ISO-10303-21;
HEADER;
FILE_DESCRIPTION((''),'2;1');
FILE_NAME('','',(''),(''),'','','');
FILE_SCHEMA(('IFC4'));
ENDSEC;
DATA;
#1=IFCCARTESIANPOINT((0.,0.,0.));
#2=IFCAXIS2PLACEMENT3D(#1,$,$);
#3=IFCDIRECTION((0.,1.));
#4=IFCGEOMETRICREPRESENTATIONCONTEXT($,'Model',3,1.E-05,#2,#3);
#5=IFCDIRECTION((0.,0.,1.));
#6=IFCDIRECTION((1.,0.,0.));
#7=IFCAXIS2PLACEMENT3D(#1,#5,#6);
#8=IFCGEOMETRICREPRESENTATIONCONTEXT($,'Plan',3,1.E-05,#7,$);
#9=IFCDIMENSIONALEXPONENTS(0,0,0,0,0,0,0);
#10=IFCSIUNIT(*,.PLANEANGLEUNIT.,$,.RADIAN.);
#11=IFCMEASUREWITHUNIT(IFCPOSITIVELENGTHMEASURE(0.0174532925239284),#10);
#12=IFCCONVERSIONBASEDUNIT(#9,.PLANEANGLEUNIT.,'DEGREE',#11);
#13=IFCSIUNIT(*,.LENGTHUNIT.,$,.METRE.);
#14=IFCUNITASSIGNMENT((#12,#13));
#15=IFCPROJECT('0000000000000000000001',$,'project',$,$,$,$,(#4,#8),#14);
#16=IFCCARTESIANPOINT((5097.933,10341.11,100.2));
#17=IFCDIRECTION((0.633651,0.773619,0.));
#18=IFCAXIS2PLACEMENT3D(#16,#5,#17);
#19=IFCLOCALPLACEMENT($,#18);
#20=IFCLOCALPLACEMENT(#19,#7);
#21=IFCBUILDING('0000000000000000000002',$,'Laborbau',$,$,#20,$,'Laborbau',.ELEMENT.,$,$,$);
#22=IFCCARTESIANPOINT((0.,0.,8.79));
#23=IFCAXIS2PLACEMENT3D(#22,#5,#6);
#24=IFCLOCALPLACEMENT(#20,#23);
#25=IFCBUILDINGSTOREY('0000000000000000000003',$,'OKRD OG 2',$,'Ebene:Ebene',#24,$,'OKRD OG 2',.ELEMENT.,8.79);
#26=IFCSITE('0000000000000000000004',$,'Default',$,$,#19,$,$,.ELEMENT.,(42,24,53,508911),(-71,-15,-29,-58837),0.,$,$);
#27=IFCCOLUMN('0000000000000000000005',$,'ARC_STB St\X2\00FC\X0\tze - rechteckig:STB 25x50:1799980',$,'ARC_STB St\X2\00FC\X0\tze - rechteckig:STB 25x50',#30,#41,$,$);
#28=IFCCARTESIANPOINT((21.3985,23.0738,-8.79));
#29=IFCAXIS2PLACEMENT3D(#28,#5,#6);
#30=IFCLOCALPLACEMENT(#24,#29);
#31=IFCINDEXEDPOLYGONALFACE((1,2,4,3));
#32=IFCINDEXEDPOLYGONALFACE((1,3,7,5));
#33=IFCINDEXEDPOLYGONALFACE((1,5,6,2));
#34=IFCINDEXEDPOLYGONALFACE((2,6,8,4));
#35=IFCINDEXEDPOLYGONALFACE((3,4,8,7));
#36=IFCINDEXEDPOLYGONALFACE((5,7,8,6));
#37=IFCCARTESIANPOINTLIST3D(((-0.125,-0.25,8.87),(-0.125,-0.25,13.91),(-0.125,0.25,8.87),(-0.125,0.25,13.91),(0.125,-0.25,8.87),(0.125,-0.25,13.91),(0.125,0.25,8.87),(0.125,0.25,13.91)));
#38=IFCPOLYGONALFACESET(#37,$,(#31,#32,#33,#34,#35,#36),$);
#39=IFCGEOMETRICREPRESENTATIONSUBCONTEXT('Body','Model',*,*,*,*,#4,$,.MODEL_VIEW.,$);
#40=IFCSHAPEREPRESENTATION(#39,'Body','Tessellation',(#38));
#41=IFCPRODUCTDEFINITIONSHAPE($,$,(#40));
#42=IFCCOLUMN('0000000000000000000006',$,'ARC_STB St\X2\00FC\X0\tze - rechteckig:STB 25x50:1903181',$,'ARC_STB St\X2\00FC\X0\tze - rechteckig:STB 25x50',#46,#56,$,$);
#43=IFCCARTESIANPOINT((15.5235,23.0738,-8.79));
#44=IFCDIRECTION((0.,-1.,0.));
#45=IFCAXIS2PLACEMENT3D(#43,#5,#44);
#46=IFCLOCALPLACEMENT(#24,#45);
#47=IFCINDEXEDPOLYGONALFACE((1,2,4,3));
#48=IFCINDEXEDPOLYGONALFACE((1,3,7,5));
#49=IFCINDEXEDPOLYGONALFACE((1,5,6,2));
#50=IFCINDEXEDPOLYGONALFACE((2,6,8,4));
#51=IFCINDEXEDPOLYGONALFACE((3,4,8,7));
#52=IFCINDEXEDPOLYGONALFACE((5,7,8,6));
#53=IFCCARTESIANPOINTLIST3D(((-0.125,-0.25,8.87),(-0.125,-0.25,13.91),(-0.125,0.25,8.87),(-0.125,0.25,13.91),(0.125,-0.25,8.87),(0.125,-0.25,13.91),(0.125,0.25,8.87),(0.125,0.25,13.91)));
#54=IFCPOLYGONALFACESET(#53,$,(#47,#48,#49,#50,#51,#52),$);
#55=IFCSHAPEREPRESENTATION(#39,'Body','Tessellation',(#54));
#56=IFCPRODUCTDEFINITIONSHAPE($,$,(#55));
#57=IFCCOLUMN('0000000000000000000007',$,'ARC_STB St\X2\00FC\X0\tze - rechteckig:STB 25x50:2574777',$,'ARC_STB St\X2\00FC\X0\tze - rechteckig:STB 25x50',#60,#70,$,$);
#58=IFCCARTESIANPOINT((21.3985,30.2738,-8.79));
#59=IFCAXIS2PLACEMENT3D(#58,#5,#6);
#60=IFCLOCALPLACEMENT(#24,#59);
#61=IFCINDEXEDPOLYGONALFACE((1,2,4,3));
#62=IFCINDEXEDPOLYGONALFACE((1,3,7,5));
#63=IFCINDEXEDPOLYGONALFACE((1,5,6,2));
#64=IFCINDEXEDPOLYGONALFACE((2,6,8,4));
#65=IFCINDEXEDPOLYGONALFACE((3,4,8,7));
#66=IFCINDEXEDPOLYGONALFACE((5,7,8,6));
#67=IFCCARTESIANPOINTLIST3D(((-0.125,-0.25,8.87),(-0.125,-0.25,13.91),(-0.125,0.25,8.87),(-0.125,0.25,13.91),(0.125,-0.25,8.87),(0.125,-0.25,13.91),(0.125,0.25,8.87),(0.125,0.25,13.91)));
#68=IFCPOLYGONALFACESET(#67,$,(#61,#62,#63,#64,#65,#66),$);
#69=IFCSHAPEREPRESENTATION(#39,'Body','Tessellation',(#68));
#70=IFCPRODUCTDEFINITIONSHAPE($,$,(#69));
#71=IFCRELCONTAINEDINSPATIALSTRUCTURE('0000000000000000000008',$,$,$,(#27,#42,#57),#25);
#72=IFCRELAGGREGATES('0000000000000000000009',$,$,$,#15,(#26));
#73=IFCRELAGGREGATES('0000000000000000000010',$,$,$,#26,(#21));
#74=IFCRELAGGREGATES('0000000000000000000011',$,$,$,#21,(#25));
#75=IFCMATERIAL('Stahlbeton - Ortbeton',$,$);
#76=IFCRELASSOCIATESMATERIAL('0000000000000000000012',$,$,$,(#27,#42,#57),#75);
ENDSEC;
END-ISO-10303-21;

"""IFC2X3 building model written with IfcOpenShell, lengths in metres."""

from ifc_helpers import new_model, entity, si_unit, converted_unit, direction, frame, origin, origin_with_axes, origin_2d_with_axis, place, context, subcontext, project, spatial, rectangle, extrude, source, transform, mapped, material, element, save


model = new_model("IFC2X3")

# Units and contexts
model_context = context("Model", 3, precision=1e-05, world=origin(), true_north=direction((0.0, 1.0)))
plan_context = context("Plan", 3, precision=1e-05, world=origin_with_axes())
body_context = subcontext(model_context, "Body", "Model", "MODEL_VIEW")
ifc_project = project(units=[converted_unit("PLANEANGLEUNIT", "DEGREE", entity("IfcPositiveLengthMeasure", 0.0174532925239284), si_unit("PLANEANGLEUNIT", "RADIAN"), dimensions=[0, 0, 0, 0, 0, 0, 0]), si_unit("LENGTHUNIT", "METRE")], contexts=[model_context, plan_context])

# Site, building, storey
site_placement = place(None, frame((5097.933, 10341.11, 100.2), z_axis=(0.0, 0.0, 1.0), x_axis=(0.633651, 0.773619, 0.0)))
site = spatial("IfcSite", under=ifc_project, at=site_placement, Name="Default", CompositionType="ELEMENT", RefLatitude=(42, 24, 53, 508911), RefLongitude=(-71, -15, -29, -58837), RefElevation=0.0)
building_placement = place(site_placement, origin_with_axes())
building = spatial("IfcBuilding", under=site, at=building_placement, Name="Laborbau", LongName="Laborbau", CompositionType="ELEMENT")
storey_placement = place(building_placement, frame((0.0, 0.0, 8.79), z_axis=(0.0, 0.0, 1.0), x_axis=(1.0, 0.0, 0.0)))
storey = spatial("IfcBuildingStorey", under=building, at=storey_placement, Name="OKRD OG 2", ObjectType="Ebene:Ebene", LongName="OKRD OG 2", CompositionType="ELEMENT", Elevation=8.79)

# Columns
ifc_material_1 = material(Name="Stahlbeton - Ortbeton")
shared_shape = source(origin(), body_context, "Body", "SweptSolid", [
    extrude(rectangle(XDim=0.5, YDim=0.25, at=origin_2d_with_axis()), frame((0.0, 0.0, 8.87), z_axis=(0.0, 0.0, 1.0), x_axis=(0.0, -1.0, 0.0)), (0.0, 0.0, 1.0), 5.04),
])
for number, where, z_axis, x_axis, name in (
    (1, (21.3985, 23.0738, -8.79), (0.0, 0.0, 1.0), (1.0, 0.0, 0.0), "ARC_STB Stütze - rechteckig:STB 25x50:1799980"),
    (2, (15.5235, 23.0738, -8.79), (0.0, 0.0, 1.0), (0.0, -1.0, 0.0), "ARC_STB Stütze - rechteckig:STB 25x50:1903181"),
    (3, (21.3985, 30.2738, -8.79), (0.0, 0.0, 1.0), (1.0, 0.0, 0.0), "ARC_STB Stütze - rechteckig:STB 25x50:2574777"),
):
    element("IfcColumn", number, at=place(storey_placement, frame(where, z_axis=z_axis, x_axis=x_axis)), inside=storey, material=ifc_material_1, Name=name, ObjectType="ARC_STB Stütze - rechteckig:STB 25x50", context=body_context, shape_type="MappedRepresentation", body=[
        mapped(shared_shape, transform((0.0, 0.0, 0.0), scale=1.0)),
    ])

save(model, "model.ifc")
